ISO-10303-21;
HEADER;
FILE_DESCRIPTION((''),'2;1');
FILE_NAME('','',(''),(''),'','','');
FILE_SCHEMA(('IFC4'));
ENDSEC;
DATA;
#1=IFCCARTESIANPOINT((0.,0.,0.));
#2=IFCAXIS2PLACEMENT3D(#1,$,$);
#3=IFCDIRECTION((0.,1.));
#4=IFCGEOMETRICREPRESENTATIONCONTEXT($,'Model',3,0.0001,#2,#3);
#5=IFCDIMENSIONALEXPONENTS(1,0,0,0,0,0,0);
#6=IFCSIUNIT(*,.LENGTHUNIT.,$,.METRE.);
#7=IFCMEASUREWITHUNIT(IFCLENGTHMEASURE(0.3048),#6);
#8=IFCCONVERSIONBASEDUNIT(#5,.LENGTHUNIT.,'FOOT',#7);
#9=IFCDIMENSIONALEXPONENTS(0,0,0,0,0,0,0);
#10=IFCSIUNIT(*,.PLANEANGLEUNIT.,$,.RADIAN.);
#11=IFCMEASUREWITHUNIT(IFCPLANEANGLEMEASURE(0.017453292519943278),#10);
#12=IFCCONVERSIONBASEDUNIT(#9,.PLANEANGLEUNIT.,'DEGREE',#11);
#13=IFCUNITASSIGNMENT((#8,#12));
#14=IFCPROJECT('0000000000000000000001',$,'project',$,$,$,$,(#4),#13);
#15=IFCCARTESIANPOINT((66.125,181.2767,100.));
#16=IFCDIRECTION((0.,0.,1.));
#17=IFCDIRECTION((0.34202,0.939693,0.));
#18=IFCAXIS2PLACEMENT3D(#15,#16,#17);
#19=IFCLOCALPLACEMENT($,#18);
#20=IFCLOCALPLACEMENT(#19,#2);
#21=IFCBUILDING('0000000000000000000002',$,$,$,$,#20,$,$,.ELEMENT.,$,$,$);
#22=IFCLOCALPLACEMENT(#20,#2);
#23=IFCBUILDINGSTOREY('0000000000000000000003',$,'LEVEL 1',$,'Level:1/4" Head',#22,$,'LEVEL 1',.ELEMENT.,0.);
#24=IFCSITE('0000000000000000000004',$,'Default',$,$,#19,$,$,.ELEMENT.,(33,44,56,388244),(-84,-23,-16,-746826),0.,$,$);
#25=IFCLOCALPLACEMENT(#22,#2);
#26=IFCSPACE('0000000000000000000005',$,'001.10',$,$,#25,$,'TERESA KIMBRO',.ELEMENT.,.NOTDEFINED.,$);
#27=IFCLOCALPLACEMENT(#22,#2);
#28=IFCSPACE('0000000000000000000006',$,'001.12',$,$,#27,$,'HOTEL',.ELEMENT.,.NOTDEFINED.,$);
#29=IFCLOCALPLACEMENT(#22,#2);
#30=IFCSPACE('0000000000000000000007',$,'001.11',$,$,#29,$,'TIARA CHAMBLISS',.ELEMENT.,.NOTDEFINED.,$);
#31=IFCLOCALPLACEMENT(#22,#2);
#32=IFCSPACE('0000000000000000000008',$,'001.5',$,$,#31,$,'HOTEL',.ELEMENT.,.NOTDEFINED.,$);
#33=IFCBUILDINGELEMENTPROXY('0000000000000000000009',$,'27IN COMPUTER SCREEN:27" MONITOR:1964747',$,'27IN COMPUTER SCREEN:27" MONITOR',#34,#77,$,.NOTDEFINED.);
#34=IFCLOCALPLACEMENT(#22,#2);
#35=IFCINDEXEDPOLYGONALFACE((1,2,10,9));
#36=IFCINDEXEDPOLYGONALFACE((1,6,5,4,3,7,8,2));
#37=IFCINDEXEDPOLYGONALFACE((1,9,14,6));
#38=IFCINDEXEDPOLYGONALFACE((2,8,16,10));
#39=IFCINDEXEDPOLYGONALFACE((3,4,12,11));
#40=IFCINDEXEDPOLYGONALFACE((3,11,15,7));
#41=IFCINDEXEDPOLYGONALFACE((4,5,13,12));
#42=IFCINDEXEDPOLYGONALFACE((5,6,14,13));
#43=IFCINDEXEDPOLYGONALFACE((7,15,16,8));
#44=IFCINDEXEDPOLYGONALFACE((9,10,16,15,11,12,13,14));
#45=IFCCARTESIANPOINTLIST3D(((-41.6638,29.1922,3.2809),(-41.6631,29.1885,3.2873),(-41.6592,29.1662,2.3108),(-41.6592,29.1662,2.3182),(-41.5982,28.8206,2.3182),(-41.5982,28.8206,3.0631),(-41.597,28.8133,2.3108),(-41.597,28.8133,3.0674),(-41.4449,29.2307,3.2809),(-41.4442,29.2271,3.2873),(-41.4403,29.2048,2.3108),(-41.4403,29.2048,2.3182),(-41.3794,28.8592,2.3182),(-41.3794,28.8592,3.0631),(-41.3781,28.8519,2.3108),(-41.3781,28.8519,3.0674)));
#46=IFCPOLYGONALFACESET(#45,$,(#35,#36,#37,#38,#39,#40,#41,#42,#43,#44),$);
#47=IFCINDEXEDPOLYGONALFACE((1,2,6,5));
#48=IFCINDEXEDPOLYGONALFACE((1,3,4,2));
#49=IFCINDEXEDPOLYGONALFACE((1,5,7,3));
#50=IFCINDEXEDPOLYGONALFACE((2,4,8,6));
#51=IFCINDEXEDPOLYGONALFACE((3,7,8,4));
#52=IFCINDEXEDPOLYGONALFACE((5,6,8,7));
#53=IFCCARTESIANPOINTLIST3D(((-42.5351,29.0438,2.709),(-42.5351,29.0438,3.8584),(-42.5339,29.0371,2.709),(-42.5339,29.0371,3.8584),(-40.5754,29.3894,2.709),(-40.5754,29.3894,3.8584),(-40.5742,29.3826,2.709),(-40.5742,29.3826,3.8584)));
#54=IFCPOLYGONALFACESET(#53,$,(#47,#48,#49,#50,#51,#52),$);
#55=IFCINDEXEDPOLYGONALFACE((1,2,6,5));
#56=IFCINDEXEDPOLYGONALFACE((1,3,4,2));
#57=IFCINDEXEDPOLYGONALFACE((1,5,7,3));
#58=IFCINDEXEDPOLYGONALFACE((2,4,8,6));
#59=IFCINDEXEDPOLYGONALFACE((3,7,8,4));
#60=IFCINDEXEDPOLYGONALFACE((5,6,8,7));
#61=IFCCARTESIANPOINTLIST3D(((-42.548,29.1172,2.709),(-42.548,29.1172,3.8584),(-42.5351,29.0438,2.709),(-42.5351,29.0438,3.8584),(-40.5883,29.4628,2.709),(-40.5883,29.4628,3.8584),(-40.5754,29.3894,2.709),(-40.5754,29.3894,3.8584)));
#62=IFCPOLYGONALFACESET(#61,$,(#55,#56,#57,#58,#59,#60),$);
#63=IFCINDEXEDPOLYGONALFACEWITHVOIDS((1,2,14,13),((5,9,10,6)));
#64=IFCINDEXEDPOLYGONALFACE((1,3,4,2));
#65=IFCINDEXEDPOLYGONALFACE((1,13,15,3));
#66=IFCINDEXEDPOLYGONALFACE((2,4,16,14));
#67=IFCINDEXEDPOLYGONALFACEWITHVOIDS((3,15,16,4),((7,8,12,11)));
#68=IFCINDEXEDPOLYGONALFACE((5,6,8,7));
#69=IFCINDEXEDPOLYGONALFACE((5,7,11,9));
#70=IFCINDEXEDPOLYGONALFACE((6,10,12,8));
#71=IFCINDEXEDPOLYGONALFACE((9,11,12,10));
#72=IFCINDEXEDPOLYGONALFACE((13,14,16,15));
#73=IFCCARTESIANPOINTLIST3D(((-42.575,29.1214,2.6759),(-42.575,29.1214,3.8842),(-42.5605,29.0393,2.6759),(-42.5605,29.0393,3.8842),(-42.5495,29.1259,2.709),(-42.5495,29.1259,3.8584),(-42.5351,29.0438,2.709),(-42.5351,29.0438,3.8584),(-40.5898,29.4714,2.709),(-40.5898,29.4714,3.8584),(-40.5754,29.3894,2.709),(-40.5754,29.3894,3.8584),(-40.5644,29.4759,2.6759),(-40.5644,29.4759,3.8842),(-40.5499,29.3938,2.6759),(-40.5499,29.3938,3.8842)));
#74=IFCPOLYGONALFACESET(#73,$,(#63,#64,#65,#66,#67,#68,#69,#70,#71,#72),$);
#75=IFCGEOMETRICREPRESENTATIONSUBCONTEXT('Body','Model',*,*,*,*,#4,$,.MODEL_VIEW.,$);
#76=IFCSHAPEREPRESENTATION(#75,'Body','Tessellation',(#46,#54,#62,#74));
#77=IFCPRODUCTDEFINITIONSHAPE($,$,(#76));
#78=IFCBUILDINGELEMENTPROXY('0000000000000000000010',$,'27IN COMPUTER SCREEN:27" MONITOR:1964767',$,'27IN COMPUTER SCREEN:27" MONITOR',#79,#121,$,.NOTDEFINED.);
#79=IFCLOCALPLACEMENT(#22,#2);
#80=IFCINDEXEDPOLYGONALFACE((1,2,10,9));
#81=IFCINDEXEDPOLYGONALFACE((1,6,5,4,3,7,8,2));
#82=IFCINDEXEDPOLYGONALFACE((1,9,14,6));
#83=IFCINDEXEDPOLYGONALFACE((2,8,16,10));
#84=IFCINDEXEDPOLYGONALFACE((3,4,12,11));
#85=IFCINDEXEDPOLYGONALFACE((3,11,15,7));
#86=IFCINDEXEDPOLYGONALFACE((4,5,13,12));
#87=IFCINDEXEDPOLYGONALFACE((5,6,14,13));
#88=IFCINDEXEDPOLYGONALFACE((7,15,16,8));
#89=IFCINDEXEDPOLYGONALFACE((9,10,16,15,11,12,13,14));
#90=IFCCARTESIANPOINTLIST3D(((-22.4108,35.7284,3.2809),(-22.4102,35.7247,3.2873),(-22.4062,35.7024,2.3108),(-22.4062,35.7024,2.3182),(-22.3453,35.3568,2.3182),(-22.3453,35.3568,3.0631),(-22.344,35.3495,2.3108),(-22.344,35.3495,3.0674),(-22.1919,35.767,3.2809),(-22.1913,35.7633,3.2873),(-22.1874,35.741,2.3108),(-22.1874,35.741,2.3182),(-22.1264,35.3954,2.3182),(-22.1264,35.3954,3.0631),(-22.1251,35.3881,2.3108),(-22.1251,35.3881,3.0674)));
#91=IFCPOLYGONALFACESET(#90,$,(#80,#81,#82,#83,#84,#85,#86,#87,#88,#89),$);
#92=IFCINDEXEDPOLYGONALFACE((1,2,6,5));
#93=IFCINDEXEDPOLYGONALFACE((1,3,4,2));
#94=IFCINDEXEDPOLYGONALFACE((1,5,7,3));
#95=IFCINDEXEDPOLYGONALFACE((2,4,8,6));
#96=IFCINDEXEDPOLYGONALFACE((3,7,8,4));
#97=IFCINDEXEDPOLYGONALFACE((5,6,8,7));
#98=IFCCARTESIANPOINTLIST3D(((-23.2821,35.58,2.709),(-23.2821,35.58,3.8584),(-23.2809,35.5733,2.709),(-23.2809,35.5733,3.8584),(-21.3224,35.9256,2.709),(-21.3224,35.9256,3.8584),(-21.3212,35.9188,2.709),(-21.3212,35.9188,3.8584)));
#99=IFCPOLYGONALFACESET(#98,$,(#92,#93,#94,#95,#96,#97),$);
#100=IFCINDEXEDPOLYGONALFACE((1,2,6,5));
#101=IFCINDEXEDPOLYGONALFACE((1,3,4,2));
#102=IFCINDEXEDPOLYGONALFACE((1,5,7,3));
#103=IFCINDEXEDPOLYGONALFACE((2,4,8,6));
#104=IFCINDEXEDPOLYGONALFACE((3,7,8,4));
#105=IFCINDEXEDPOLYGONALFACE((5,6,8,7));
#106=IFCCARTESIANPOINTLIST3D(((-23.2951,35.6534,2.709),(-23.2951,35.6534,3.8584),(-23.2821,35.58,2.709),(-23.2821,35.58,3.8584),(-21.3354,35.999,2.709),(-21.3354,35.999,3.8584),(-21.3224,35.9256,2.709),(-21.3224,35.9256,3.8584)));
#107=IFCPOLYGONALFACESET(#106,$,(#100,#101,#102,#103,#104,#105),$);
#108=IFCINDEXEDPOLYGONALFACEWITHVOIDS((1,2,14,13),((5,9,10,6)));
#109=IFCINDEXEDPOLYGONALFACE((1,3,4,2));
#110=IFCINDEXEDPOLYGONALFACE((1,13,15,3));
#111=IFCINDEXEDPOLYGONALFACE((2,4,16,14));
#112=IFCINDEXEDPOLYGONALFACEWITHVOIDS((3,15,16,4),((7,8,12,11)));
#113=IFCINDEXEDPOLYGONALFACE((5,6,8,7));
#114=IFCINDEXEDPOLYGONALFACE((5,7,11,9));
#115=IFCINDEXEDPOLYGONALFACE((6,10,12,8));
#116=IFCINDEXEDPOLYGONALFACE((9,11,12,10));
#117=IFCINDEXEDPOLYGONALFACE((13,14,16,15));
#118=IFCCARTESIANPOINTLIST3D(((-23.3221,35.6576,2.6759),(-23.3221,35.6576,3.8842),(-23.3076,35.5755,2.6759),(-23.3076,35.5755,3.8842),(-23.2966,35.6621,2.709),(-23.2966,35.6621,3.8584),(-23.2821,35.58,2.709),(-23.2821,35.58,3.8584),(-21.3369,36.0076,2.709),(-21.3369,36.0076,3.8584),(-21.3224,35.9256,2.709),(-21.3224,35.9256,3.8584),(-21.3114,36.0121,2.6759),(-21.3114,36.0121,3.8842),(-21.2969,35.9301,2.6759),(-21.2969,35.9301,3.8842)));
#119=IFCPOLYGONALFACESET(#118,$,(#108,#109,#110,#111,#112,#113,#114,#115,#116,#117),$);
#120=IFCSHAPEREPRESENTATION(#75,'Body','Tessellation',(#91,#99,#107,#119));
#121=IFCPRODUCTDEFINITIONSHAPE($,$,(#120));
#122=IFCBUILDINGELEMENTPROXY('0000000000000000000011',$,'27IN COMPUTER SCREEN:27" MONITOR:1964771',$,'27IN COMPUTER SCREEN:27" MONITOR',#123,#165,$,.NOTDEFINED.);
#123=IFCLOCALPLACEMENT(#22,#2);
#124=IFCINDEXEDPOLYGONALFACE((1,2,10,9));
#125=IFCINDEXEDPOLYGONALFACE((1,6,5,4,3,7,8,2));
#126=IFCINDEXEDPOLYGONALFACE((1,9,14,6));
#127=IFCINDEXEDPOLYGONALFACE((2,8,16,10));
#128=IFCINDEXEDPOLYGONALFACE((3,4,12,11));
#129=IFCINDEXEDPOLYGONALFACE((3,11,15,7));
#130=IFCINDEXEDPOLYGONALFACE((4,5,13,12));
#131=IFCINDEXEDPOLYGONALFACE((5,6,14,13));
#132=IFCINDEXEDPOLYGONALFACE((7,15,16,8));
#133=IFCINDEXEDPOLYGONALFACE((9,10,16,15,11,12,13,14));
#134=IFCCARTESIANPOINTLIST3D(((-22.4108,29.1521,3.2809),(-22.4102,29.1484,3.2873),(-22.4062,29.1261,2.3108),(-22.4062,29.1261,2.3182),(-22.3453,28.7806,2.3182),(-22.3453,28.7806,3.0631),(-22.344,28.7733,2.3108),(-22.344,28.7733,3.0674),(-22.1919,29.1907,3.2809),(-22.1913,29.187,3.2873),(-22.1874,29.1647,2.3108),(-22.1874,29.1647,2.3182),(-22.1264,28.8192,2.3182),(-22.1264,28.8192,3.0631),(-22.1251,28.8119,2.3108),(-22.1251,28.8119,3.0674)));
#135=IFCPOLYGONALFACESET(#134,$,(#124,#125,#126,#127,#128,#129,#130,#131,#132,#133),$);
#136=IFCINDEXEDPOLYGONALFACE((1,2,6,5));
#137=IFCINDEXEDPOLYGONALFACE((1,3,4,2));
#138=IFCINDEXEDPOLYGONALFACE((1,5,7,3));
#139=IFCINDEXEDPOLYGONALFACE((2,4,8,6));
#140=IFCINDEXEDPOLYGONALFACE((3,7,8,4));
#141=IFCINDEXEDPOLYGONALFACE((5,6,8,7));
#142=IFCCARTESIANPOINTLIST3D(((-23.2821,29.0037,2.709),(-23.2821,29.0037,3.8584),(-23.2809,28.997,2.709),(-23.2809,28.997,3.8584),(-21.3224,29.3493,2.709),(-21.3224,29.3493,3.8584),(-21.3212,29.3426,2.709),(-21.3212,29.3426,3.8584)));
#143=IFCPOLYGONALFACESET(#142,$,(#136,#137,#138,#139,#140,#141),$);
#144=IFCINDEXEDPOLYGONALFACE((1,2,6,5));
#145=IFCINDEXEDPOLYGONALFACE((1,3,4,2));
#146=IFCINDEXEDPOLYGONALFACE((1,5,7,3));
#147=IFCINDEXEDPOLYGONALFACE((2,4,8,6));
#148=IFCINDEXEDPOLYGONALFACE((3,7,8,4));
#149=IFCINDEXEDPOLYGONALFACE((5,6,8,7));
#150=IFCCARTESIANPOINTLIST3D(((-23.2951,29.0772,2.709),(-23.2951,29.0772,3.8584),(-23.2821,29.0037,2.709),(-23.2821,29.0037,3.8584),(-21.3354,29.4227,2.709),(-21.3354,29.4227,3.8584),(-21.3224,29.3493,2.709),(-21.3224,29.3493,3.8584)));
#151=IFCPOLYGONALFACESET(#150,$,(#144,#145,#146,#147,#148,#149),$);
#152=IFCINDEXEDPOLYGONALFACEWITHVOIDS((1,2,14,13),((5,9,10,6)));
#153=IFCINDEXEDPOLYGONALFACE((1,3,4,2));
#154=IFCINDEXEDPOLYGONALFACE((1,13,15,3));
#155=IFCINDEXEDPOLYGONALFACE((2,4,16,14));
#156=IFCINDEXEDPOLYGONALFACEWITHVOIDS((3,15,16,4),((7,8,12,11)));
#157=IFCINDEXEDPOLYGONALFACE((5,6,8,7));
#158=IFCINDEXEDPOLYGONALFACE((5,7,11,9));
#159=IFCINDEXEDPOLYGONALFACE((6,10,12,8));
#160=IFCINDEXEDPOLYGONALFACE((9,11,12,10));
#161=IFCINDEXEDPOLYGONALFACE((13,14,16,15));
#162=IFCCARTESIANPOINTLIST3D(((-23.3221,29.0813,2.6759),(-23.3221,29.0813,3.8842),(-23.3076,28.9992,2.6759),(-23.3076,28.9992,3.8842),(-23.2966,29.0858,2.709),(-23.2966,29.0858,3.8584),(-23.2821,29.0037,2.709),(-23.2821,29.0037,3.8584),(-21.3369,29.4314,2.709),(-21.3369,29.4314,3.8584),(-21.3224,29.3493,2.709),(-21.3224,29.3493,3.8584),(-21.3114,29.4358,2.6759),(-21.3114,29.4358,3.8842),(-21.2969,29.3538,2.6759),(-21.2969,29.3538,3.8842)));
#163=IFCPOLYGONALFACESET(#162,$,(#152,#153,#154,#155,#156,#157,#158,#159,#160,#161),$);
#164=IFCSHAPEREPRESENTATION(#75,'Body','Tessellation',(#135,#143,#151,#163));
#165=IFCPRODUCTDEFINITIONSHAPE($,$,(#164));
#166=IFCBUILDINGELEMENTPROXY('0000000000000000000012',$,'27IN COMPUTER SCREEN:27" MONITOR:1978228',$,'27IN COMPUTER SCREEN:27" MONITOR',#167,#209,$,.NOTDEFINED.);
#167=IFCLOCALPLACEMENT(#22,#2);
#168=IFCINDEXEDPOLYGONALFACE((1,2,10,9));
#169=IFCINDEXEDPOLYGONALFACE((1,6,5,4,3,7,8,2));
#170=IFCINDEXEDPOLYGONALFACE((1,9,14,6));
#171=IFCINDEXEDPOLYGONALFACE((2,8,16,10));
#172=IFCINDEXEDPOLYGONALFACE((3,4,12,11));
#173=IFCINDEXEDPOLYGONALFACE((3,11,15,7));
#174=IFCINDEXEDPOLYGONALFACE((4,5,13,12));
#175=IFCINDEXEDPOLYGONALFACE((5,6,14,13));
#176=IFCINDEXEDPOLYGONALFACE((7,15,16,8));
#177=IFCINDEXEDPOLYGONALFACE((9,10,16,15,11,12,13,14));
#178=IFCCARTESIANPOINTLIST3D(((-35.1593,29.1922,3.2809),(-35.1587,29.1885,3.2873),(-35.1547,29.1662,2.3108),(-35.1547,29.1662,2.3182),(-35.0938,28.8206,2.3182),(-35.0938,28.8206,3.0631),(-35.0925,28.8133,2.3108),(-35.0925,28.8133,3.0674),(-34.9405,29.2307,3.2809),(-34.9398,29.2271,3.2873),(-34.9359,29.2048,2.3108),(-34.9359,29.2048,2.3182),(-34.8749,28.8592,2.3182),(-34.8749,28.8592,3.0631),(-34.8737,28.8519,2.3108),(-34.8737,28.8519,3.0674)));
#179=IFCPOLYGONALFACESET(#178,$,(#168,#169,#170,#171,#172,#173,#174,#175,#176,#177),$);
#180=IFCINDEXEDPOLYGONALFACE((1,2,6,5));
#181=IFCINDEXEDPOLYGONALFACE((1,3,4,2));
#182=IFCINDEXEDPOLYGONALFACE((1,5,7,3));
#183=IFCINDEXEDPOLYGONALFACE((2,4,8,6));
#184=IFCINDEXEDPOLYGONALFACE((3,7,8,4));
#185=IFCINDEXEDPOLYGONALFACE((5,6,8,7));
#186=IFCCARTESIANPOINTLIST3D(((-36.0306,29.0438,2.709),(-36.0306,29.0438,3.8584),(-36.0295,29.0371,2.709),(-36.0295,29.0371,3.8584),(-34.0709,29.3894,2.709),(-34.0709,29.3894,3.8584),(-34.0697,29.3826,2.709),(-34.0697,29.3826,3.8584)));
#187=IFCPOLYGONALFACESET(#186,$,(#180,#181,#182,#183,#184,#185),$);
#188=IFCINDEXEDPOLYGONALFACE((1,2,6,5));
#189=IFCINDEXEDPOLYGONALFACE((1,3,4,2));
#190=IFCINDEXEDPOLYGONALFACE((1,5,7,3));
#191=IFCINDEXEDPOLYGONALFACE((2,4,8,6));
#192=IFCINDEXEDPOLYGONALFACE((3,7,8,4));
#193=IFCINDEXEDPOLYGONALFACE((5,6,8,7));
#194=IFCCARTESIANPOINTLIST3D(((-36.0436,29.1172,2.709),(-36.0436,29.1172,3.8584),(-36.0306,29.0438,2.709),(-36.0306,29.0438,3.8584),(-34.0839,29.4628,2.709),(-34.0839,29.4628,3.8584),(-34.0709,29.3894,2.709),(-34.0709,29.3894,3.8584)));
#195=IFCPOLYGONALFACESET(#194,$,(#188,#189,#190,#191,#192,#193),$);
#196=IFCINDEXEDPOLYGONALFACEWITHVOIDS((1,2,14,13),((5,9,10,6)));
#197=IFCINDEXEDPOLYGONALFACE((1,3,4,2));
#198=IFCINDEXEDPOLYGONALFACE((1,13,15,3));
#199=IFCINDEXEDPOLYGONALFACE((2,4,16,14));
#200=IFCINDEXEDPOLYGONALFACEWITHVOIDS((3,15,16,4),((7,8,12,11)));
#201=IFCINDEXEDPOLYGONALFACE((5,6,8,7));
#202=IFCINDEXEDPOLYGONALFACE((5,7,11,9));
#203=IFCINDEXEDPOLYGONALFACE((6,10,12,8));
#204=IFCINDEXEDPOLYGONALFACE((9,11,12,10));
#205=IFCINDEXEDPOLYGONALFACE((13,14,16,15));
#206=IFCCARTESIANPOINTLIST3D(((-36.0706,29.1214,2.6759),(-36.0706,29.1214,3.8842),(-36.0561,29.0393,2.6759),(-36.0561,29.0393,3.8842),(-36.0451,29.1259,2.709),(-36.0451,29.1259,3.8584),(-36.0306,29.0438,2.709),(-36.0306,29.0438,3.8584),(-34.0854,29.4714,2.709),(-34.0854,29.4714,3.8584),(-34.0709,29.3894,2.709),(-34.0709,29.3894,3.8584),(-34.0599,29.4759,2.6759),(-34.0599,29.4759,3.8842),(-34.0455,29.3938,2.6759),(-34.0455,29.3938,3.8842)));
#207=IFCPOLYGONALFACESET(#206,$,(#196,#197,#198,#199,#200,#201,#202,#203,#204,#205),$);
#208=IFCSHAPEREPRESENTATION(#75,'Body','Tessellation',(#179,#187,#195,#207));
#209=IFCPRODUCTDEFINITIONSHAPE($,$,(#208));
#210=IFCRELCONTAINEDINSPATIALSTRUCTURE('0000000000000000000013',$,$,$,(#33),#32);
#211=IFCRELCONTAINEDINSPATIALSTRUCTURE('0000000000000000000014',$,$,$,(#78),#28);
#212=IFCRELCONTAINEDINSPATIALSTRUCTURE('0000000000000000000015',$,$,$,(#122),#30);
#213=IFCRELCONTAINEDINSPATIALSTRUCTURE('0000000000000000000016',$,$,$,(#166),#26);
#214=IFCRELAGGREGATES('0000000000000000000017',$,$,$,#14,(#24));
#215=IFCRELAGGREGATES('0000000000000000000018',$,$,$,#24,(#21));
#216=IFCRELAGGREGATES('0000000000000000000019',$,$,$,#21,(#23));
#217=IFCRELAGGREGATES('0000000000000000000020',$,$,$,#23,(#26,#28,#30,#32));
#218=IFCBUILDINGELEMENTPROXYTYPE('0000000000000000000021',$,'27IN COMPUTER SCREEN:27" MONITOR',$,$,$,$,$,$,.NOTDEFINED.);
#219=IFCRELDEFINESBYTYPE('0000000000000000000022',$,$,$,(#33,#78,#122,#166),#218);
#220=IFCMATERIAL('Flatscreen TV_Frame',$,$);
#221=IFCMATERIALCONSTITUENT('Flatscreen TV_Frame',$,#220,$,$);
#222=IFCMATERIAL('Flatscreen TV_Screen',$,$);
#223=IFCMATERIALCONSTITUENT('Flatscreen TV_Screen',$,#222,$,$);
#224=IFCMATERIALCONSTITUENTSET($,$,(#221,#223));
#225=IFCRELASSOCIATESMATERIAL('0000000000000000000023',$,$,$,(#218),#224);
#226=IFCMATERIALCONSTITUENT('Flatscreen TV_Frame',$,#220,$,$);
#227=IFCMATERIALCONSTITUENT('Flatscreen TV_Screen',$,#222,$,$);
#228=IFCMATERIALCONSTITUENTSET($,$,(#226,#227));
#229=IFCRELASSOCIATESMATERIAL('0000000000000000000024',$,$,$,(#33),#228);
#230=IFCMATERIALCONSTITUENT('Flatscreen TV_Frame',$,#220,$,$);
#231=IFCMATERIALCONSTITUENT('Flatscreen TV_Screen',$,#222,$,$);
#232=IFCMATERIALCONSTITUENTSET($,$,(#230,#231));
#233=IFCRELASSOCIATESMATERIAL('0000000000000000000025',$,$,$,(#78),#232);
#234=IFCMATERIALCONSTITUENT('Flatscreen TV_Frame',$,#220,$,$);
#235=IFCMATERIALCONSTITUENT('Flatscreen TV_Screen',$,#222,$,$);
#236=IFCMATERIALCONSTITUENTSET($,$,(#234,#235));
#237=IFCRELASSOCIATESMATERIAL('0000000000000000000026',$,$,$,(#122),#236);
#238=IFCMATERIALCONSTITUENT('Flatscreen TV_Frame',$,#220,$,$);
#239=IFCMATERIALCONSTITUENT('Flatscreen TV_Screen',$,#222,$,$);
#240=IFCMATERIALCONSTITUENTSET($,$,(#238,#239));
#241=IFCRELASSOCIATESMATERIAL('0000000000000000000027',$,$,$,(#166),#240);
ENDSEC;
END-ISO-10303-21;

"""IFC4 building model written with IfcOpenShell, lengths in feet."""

from ifc_helpers import new_model, entity, si_unit, converted_unit, direction, frame, frame_2d, origin, origin_2d_with_axis, place, context, subcontext, project, spatial, polyline, rectangle, outline, extrude, source, transform, mapped, material, constituent, constituent_set, type_object, type_shapes, element, save


model = new_model("IFC4")

# Units and contexts
model_context = context("Model", 3, precision=0.0001, world=origin(), true_north=direction((0.0, 1.0)))
body_context = subcontext(model_context, "Body", "Model", "MODEL_VIEW")
ifc_project = project(units=[converted_unit("LENGTHUNIT", "FOOT", entity("IfcLengthMeasure", 0.3048), si_unit("LENGTHUNIT", "METRE"), dimensions=[1, 0, 0, 0, 0, 0, 0]), converted_unit("PLANEANGLEUNIT", "DEGREE", entity("IfcPlaneAngleMeasure", 0.017453292519943278), si_unit("PLANEANGLEUNIT", "RADIAN"), dimensions=[0, 0, 0, 0, 0, 0, 0])], contexts=[model_context])

# Site, building, storey
site_placement = place(None, frame((66.125, 181.2767, 100.0), z_axis=(0.0, 0.0, 1.0), x_axis=(0.34202, 0.939693, 0.0)))
site = spatial("IfcSite", under=ifc_project, at=site_placement, Name="Default", CompositionType="ELEMENT", RefLatitude=(33, 44, 56, 388244), RefLongitude=(-84, -23, -16, -746826), RefElevation=0.0)
building_placement = place(site_placement, origin())
building = spatial("IfcBuilding", under=site, at=building_placement, CompositionType="ELEMENT")
storey_placement = place(building_placement, origin())
storey = spatial("IfcBuildingStorey", under=building, at=storey_placement, Name="LEVEL 1", ObjectType="Level:1/4\" Head", LongName="LEVEL 1", CompositionType="ELEMENT", Elevation=0.0)

# Shared definitions
space_1_placement = place(storey_placement, origin())
space_1 = spatial("IfcSpace", under=storey, at=space_1_placement, Name="001.10", LongName="TERESA KIMBRO", CompositionType="ELEMENT", PredefinedType="NOTDEFINED")

# Shared definitions
ifc_material_1 = material(Name="Flatscreen TV_Frame")
ifc_material_2 = material(Name="Flatscreen TV_Screen")

# Shared definitions
space_2_placement = place(storey_placement, origin())
space_2 = spatial("IfcSpace", under=storey, at=space_2_placement, Name="001.12", LongName="HOTEL", CompositionType="ELEMENT", PredefinedType="NOTDEFINED")

# Shared definitions
space_3_placement = place(storey_placement, origin())
space_3 = spatial("IfcSpace", under=storey, at=space_3_placement, Name="001.11", LongName="TIARA CHAMBLISS", CompositionType="ELEMENT", PredefinedType="NOTDEFINED")

# Shared definitions
space_4_placement = place(storey_placement, origin())
space_4 = spatial("IfcSpace", under=storey, at=space_4_placement, Name="001.5", LongName="HOTEL", CompositionType="ELEMENT", PredefinedType="NOTDEFINED")

# Building element proxies
ifc_constituent_1 = constituent(ifc_material_1, Name="Flatscreen TV_Frame")
ifc_constituent_2 = constituent(ifc_material_2, Name="Flatscreen TV_Screen")
ifc_constituent_set_1 = constituent_set(constituents=[ifc_constituent_1, ifc_constituent_2])
ifc_constituent_3 = constituent(ifc_material_1, Name="Flatscreen TV_Frame")
ifc_constituent_4 = constituent(ifc_material_2, Name="Flatscreen TV_Screen")
ifc_constituent_set_2 = constituent_set(constituents=[ifc_constituent_3, ifc_constituent_4])
building_element_proxy_type_1 = type_object("IfcBuildingElementProxyType", Name="27IN COMPUTER SCREEN:27\" MONITOR", PredefinedType="NOTDEFINED", material=ifc_constituent_set_2)
shared_shape_1 = source(origin(), body_context, "Body", "SweptSolid", [
    extrude(outline(polyline([(0.3657, -0.4392), (0.3731, -0.4392), (0.3731, 0.0007), (-0.2821, 0.379), (-0.4613, 0.0686), (-0.4548, 0.0649), (-0.2794, 0.3688), (0.3657, -0.0036), (0.3657, -0.4392)])), frame((-0.1111, 0.0264, 0.0687), z_axis=(1.0, 0.0, 0.0), x_axis=(0.0, -0.5, 0.866025)), (0.0, 0.0, 1.0), 0.2222),
    extrude(rectangle(XDim=1.9899, YDim=0.0068, at=origin_2d_with_axis()), frame((0.0, 0.2257, 0.0331), z_axis=(0.0, 0.0, 1.0), x_axis=(-1.0, 0.0, 0.0)), (0.0, 0.0, 1.0), 1.1493),
    extrude(rectangle(XDim=1.9899, YDim=0.0746, at=frame_2d((0.0, 0.0), x_axis=(1.0, 0.0))), frame((0.0, 0.2664, 0.0331), z_axis=(0.0, 0.0, 1.0), x_axis=(-1.0, 0.0, 0.0)), (0.0, 0.0, 1.0), 1.1493),
    extrude(outline(polyline([(-0.6042, -1.0208), (0.6042, -1.0208), (0.6042, 1.0208), (-0.6042, 1.0208), (-0.6042, -1.0208)]), holes=[polyline([(-0.5783, -0.995), (-0.5783, 0.995), (0.571, 0.995), (0.571, -0.995), (-0.5783, -0.995)])]), frame((0.0, 0.2292, 0.6042), z_axis=(0.0, 1.0, 0.0), x_axis=(0.0, 0.0, -1.0)), (0.0, 0.0, 1.0), 0.0833),
])
type_shapes(building_element_proxy_type_1, [shared_shape_1])
proxy_1_placement = place(space_4_placement, frame((-41.5154, 28.9909, 2.6759), z_axis=(0.0, 0.0, 1.0), x_axis=(0.984808, 0.173648, 0.0)))
element("IfcBuildingElementProxy", 1, at=proxy_1_placement, inside=space_4, type_object=building_element_proxy_type_1, material=ifc_constituent_set_1, Name="27IN COMPUTER SCREEN:27\" MONITOR:1964747", ObjectType="27IN COMPUTER SCREEN:27\" MONITOR", PredefinedType="NOTDEFINED", context=body_context, shape_type="MappedRepresentation", body=[
    mapped(shared_shape_1, transform((0.0, 0.0, 0.0), scale=1.0)),
])
ifc_constituent_5 = constituent(ifc_material_1, Name="Flatscreen TV_Frame")
ifc_constituent_6 = constituent(ifc_material_2, Name="Flatscreen TV_Screen")
ifc_constituent_set_3 = constituent_set(constituents=[ifc_constituent_5, ifc_constituent_6])
proxy_2_placement = place(space_2_placement, frame((-22.2625, 35.5271, 2.6759), z_axis=(0.0, 0.0, 1.0), x_axis=(0.984808, 0.173648, 0.0)))
element("IfcBuildingElementProxy", 2, at=proxy_2_placement, inside=space_2, type_object=building_element_proxy_type_1, material=ifc_constituent_set_3, Name="27IN COMPUTER SCREEN:27\" MONITOR:1964767", ObjectType="27IN COMPUTER SCREEN:27\" MONITOR", PredefinedType="NOTDEFINED", context=body_context, shape_type="MappedRepresentation", body=[
    mapped(shared_shape_1, transform((0.0, 0.0, 0.0), scale=1.0)),
])
ifc_constituent_7 = constituent(ifc_material_1, Name="Flatscreen TV_Frame")
ifc_constituent_8 = constituent(ifc_material_2, Name="Flatscreen TV_Screen")
ifc_constituent_set_4 = constituent_set(constituents=[ifc_constituent_7, ifc_constituent_8])
proxy_3_placement = place(space_3_placement, frame((-22.2625, 28.9508, 2.6759), z_axis=(0.0, 0.0, 1.0), x_axis=(0.984808, 0.173648, 0.0)))
element("IfcBuildingElementProxy", 3, at=proxy_3_placement, inside=space_3, type_object=building_element_proxy_type_1, material=ifc_constituent_set_4, Name="27IN COMPUTER SCREEN:27\" MONITOR:1964771", ObjectType="27IN COMPUTER SCREEN:27\" MONITOR", PredefinedType="NOTDEFINED", context=body_context, shape_type="MappedRepresentation", body=[
    mapped(shared_shape_1, transform((0.0, 0.0, 0.0), scale=1.0)),
])
ifc_constituent_9 = constituent(ifc_material_1, Name="Flatscreen TV_Frame")
ifc_constituent_10 = constituent(ifc_material_2, Name="Flatscreen TV_Screen")
ifc_constituent_set_5 = constituent_set(constituents=[ifc_constituent_9, ifc_constituent_10])
proxy_4_placement = place(space_1_placement, frame((-35.011, 28.9909, 2.6759), z_axis=(0.0, 0.0, 1.0), x_axis=(0.984808, 0.173648, 0.0)))
element("IfcBuildingElementProxy", 4, at=proxy_4_placement, inside=space_1, type_object=building_element_proxy_type_1, material=ifc_constituent_set_5, Name="27IN COMPUTER SCREEN:27\" MONITOR:1978228", ObjectType="27IN COMPUTER SCREEN:27\" MONITOR", PredefinedType="NOTDEFINED", context=body_context, shape_type="MappedRepresentation", body=[
    mapped(shared_shape_1, transform((0.0, 0.0, 0.0), scale=1.0)),
])

save(model, "model.ifc")
